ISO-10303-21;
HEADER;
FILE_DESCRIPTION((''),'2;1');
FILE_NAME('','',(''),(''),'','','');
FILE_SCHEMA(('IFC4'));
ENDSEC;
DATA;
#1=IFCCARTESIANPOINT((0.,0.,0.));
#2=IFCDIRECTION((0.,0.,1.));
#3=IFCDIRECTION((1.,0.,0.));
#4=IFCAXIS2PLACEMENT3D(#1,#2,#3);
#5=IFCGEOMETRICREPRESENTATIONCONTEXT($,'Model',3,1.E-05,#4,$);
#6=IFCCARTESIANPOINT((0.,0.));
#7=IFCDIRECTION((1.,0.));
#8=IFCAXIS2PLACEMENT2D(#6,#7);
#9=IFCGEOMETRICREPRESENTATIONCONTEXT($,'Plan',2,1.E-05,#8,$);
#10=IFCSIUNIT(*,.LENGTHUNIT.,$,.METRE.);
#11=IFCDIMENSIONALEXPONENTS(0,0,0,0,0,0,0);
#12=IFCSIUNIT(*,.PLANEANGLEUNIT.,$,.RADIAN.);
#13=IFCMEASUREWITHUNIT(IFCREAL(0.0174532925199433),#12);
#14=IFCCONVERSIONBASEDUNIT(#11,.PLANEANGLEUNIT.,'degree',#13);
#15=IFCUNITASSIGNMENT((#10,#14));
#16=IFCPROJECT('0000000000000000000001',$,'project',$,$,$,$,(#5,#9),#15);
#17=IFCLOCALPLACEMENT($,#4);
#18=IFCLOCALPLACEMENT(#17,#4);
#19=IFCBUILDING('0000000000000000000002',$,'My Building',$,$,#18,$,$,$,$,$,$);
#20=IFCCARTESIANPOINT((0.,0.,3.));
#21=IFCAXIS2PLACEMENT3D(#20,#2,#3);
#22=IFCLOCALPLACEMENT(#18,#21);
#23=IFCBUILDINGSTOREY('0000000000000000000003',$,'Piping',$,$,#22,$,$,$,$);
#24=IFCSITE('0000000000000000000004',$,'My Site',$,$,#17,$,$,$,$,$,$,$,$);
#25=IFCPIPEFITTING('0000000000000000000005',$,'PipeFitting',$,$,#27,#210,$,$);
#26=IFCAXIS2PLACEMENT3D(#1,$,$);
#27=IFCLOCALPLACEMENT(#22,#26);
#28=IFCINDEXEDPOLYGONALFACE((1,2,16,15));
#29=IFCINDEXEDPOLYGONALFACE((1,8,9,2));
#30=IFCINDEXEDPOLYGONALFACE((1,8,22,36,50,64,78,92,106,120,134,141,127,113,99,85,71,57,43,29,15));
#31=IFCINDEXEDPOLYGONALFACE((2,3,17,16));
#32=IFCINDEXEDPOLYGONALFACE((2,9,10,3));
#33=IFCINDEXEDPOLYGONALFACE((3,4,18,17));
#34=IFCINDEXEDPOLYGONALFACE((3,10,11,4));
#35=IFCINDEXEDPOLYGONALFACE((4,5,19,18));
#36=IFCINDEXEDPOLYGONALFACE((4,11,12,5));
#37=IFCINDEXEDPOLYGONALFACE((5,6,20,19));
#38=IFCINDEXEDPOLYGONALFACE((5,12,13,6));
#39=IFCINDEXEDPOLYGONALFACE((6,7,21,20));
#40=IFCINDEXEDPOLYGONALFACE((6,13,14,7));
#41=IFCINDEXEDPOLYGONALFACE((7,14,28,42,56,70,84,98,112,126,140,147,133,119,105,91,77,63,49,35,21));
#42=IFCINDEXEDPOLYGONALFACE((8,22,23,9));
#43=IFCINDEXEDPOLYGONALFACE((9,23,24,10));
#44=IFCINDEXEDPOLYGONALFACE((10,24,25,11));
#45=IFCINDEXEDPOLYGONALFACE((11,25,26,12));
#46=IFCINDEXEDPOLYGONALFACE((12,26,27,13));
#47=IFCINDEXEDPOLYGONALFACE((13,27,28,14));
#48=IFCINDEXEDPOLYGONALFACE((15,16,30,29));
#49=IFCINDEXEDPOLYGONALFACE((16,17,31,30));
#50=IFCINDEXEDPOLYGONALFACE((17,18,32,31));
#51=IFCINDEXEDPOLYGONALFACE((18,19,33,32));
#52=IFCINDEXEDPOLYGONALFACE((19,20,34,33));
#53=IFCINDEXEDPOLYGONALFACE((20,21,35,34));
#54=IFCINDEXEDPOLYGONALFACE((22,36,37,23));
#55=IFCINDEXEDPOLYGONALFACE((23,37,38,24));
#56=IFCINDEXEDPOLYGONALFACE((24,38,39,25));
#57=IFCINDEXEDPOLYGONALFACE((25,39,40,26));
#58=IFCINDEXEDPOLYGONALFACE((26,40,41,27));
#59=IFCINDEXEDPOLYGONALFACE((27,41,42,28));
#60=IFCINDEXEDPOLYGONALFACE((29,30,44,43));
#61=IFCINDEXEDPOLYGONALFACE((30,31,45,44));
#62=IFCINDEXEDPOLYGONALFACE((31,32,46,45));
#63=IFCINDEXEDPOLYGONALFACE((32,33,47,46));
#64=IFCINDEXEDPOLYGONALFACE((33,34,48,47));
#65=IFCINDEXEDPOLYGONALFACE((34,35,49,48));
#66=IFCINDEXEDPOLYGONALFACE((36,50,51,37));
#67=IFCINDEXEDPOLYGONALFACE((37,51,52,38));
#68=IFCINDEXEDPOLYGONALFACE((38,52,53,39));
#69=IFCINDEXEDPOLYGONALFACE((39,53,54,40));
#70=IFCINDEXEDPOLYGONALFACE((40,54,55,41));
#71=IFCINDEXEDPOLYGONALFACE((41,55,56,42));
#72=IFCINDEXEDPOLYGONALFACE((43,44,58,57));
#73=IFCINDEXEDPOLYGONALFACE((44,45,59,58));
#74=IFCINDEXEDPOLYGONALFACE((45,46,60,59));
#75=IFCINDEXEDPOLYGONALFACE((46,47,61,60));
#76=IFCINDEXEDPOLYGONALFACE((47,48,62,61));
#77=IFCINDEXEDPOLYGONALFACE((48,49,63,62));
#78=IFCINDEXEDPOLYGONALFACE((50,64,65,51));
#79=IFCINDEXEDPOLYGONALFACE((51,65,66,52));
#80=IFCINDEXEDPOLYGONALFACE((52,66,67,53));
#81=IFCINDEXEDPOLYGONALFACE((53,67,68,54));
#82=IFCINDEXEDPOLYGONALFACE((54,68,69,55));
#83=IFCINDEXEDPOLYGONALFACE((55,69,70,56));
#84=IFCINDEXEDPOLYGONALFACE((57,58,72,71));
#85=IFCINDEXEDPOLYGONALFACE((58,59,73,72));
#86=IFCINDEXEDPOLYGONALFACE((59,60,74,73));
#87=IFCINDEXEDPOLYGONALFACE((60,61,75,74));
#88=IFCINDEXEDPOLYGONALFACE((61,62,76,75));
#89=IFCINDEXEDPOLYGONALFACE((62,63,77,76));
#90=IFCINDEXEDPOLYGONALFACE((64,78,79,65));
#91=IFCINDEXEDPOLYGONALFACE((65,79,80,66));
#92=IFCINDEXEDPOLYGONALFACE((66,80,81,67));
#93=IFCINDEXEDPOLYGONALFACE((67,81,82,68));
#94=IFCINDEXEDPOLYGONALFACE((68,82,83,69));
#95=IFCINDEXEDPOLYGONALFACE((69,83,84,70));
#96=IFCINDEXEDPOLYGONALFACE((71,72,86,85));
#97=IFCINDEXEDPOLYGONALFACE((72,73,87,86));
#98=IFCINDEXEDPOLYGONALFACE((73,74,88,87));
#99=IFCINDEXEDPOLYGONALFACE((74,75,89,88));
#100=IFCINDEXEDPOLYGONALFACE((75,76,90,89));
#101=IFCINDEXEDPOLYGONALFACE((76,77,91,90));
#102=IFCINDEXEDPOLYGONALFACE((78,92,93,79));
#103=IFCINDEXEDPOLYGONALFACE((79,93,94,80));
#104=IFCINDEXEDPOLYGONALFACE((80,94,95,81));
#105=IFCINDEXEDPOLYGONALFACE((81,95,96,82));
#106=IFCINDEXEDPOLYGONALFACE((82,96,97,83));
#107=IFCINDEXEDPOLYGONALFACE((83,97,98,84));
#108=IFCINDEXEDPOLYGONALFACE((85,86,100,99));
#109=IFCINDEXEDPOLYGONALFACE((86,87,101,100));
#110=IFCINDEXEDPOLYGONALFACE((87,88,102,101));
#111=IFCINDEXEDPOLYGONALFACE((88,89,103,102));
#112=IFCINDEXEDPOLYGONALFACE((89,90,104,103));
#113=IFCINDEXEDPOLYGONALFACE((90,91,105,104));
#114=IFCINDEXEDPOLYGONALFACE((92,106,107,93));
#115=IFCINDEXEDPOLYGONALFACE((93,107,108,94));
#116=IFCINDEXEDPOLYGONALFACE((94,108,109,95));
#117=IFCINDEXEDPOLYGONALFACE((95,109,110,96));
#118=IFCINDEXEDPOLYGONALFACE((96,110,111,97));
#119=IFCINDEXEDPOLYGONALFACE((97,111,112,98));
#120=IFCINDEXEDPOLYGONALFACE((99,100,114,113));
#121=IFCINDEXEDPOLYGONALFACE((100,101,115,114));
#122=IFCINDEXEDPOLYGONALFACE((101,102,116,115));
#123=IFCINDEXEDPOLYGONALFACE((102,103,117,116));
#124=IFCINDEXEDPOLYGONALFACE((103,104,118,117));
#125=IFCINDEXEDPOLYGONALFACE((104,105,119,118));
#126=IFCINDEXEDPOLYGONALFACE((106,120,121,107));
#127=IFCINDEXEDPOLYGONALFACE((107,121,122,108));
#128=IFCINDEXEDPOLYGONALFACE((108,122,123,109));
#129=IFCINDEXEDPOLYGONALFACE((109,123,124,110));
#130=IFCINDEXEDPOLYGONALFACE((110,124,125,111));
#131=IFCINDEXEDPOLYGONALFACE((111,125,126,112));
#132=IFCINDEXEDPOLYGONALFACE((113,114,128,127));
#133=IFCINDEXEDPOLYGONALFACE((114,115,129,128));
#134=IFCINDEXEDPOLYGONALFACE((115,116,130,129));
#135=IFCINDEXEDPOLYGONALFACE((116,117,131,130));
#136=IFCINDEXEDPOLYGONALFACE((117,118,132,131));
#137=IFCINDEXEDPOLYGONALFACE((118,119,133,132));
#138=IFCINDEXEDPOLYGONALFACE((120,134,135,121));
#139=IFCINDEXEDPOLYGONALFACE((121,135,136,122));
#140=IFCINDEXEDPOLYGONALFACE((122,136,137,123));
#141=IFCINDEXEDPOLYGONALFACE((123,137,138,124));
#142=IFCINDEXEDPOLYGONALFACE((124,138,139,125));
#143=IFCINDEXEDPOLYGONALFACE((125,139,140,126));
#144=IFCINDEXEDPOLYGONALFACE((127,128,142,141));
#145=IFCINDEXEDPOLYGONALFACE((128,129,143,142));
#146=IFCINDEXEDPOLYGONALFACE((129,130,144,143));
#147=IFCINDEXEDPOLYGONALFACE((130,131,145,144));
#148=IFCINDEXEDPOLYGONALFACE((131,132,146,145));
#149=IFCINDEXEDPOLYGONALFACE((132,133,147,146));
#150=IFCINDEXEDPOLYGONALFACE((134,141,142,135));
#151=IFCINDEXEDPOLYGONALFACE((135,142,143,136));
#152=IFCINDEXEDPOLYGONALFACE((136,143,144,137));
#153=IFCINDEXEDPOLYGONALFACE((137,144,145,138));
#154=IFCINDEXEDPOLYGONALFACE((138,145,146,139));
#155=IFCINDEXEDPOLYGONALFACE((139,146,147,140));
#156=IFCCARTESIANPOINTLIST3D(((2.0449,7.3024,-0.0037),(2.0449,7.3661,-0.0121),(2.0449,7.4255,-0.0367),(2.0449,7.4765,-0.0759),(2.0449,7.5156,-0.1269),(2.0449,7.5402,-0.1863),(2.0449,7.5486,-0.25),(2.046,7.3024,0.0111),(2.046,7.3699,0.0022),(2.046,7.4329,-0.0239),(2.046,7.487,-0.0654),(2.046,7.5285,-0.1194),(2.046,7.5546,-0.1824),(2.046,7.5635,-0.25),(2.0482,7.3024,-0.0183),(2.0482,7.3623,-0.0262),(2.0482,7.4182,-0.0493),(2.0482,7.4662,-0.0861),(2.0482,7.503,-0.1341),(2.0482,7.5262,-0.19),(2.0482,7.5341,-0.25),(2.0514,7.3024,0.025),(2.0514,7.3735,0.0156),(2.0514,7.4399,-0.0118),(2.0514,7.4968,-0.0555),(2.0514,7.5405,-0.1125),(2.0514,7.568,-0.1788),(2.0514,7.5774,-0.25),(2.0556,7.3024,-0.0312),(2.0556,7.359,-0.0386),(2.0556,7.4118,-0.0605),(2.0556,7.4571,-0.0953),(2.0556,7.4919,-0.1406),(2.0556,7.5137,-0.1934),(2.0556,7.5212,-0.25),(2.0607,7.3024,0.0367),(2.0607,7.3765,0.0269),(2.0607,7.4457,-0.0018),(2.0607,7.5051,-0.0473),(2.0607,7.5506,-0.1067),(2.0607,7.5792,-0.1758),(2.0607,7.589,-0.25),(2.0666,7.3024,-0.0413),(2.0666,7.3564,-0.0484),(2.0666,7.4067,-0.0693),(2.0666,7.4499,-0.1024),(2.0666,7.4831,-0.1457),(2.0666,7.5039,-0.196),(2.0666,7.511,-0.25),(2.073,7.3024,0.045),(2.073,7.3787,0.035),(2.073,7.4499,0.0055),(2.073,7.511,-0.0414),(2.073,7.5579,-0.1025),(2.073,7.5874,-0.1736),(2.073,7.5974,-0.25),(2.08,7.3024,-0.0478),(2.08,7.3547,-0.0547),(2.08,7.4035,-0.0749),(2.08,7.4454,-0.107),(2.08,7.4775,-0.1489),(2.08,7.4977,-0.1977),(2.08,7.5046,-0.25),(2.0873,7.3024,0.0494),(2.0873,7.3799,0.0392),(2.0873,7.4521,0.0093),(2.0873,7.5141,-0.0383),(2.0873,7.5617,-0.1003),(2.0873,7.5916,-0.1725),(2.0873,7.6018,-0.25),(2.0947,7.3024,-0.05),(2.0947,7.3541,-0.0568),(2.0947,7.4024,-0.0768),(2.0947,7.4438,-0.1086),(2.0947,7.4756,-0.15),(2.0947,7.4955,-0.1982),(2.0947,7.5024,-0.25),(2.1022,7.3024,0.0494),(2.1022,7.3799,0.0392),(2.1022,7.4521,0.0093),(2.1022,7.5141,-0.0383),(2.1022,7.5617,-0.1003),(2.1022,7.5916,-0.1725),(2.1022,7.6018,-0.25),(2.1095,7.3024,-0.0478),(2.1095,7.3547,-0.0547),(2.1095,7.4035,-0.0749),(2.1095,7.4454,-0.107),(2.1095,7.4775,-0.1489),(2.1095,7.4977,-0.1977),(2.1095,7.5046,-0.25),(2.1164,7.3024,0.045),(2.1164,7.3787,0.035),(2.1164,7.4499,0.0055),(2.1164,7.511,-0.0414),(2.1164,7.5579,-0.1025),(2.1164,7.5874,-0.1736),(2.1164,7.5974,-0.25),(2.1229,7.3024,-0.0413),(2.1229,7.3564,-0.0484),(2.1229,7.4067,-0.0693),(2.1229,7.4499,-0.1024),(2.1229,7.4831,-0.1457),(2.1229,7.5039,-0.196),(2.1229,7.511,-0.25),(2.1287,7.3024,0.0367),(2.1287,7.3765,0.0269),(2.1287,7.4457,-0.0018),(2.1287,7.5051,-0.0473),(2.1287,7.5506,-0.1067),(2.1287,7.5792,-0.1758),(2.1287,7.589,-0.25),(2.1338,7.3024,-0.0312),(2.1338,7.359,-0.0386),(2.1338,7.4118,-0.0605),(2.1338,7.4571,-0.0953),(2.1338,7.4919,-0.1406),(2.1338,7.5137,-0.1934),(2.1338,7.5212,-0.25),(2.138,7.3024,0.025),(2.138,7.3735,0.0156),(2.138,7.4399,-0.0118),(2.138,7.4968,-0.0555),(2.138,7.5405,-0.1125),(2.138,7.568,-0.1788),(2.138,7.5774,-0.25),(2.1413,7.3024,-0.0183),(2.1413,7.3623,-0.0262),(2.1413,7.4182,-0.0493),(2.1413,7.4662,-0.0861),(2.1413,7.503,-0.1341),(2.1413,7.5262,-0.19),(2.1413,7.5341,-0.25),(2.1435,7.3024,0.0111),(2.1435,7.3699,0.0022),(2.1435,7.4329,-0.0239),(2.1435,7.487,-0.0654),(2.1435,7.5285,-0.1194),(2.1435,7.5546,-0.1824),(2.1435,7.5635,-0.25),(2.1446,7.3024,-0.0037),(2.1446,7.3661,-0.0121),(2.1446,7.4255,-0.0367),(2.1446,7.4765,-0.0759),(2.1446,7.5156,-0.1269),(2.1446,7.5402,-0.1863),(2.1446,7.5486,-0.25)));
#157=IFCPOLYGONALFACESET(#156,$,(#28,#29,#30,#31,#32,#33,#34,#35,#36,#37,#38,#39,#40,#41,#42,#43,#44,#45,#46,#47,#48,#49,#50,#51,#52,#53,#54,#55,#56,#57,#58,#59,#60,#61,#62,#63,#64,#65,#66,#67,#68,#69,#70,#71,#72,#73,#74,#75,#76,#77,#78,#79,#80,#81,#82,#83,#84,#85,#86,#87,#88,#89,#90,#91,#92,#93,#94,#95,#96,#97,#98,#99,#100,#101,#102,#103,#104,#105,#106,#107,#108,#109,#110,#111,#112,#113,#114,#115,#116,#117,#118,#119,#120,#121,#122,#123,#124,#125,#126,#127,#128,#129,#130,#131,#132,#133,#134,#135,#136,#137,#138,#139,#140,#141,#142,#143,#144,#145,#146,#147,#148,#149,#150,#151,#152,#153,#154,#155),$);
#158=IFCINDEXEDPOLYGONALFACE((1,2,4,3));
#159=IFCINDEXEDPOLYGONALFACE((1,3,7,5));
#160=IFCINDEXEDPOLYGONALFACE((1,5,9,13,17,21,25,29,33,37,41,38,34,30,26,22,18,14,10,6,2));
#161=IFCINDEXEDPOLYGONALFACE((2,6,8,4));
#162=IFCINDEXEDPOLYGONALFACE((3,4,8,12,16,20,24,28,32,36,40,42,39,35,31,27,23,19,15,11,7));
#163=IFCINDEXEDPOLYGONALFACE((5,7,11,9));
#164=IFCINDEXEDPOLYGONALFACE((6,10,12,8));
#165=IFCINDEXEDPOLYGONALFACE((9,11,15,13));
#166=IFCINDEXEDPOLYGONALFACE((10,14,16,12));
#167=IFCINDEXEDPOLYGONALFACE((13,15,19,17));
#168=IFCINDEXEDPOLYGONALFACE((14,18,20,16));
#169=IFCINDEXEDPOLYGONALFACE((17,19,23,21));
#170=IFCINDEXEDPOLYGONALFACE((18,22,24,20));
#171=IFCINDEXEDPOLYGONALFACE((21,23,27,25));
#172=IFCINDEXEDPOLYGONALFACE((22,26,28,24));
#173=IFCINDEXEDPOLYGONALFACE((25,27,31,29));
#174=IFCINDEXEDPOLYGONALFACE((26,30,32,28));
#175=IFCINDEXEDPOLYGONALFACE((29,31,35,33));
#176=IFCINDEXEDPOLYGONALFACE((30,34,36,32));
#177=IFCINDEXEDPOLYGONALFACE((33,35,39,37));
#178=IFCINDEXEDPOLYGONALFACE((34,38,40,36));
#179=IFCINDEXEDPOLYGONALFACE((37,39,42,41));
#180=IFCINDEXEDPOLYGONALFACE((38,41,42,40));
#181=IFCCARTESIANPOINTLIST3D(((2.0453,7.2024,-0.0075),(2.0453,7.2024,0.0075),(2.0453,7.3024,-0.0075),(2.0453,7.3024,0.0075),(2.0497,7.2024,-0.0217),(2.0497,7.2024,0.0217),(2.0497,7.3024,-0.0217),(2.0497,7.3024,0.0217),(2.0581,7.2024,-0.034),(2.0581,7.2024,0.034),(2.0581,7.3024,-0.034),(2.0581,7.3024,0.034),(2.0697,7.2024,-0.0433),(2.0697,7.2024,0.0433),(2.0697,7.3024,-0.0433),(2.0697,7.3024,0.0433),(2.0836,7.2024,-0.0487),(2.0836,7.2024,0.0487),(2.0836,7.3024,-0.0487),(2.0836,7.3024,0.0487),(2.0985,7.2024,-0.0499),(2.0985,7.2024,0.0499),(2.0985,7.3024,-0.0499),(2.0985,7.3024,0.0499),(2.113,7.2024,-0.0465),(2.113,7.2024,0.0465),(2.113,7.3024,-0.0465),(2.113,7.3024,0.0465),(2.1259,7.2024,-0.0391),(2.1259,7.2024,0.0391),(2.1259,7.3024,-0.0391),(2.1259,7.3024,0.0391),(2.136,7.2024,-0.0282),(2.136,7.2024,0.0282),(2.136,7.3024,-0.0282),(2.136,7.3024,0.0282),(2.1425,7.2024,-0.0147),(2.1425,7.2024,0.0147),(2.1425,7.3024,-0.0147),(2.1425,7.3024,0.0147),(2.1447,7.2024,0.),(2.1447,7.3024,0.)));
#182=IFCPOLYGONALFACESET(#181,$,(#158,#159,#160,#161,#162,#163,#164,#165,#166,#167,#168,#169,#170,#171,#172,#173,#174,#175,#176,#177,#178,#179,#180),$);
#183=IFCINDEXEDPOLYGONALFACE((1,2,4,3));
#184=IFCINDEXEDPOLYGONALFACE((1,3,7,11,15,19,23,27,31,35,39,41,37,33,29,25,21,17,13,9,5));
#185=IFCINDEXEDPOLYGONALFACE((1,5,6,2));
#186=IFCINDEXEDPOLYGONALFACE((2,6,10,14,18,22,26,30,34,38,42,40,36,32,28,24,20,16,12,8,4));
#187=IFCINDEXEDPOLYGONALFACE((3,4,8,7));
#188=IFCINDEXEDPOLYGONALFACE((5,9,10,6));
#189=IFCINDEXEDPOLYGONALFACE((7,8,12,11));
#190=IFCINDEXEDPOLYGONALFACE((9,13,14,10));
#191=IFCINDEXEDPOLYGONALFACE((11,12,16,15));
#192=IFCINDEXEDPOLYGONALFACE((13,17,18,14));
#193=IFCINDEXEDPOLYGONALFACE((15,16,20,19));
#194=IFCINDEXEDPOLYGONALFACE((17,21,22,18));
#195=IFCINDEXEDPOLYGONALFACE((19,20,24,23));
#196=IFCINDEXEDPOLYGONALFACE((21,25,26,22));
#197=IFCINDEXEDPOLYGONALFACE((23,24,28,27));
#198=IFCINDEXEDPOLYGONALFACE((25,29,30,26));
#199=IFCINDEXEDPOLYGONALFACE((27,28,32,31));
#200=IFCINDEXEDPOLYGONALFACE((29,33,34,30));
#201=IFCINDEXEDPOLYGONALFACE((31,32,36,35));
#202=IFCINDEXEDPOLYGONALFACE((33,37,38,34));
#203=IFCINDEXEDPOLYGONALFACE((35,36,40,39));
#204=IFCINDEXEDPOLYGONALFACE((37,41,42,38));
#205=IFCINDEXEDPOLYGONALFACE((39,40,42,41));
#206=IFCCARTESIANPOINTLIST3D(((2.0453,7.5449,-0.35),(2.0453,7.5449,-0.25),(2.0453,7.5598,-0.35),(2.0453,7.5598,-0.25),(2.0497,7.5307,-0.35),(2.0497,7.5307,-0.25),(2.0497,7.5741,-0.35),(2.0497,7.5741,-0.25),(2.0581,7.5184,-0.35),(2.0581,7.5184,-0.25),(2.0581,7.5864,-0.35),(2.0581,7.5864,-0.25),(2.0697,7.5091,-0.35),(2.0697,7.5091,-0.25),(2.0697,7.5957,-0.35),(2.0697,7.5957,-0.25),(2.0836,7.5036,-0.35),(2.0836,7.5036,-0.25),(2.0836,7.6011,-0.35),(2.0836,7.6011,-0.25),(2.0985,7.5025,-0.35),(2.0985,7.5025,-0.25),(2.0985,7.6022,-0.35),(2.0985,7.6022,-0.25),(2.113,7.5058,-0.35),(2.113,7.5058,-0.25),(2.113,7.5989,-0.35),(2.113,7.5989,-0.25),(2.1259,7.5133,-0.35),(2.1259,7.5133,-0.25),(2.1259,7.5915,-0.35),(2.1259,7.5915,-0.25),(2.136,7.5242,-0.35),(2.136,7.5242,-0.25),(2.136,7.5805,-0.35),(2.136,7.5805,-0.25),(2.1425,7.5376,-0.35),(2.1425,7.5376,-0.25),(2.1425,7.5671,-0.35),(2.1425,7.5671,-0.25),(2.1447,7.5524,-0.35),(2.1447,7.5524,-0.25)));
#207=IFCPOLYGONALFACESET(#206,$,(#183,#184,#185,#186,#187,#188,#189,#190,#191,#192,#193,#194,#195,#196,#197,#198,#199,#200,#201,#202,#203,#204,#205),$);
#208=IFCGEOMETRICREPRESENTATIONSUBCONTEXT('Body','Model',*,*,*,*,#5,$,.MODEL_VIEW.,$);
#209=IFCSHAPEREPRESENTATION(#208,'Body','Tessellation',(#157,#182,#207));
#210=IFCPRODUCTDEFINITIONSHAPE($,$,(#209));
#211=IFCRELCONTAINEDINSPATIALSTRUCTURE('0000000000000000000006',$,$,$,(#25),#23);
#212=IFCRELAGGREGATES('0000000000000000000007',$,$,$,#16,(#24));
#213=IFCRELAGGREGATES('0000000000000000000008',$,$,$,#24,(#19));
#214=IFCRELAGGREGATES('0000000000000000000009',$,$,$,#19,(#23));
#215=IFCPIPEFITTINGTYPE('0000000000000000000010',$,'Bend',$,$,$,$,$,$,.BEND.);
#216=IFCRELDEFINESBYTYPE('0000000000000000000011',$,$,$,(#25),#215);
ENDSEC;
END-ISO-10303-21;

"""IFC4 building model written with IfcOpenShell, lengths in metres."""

from ifc_helpers import new_model, entity, si_unit, converted_unit, frame, origin_with_axes, origin_2d_with_axis, place, context, subcontext, project, spatial, line, indexed_curve, circle, outline, extrude, source, transform, mapped, type_object, type_shapes, element, save


model = new_model("IFC4")

# Units and contexts
model_context = context("Model", 3, precision=1e-05, world=origin_with_axes())
plan_context = context("Plan", 2, precision=1e-05, world=origin_2d_with_axis())
body_context = subcontext(model_context, "Body", "Model", "MODEL_VIEW")
ifc_project = project(units=[si_unit("LENGTHUNIT", "METRE"), converted_unit("PLANEANGLEUNIT", "degree", entity("IfcReal", 0.0174532925199433), si_unit("PLANEANGLEUNIT", "RADIAN"), dimensions=[0, 0, 0, 0, 0, 0, 0])], contexts=[model_context, plan_context])

# Site, building, storey
site_placement = place(None, origin_with_axes())
site = spatial("IfcSite", under=ifc_project, at=site_placement, Name="My Site")
building_placement = place(site_placement, origin_with_axes())
building = spatial("IfcBuilding", under=site, at=building_placement, Name="My Building")
storey_placement = place(building_placement, frame((0.0, 0.0, 3.0), z_axis=(0.0, 0.0, 1.0), x_axis=(1.0, 0.0, 0.0)))
storey = spatial("IfcBuildingStorey", under=building, at=storey_placement, Name="Piping")

# Shared definitions
pipe_fitting_type_1 = type_object("IfcPipeFittingType", Name="Bend", PredefinedType="BEND")
shared_shape = source(origin_with_axes(), body_context, "Body", "SolidModel", [
    entity("IfcSweptDiskSolid", entity("IfcIndexedPolyCurve", entity("IfcCartesianPointList3D", [[0.0, 0.0, -0.1], [0.0, -0.0732, -0.2768], [0.0, -0.25, -0.35]]), [entity("IfcArcIndex", [1, 2, 3])]), 0.05),
    extrude(circle(Radius=0.05), origin_with_axes(), (0.0, 0.0, -1.0), 0.1),
    extrude(circle(Radius=0.05), frame((0.0, -0.25, -0.35), z_axis=(0.0, -1.0, 0.0), x_axis=(1.0, 0.0, 0.0)), (0.0, 0.0, 1.0), 0.1),
])
type_shapes(pipe_fitting_type_1, [shared_shape])

# Pipe fitting, opening
pipe_fitting_1_placement = place(storey_placement, frame((2.0947, 7.2024, 0.0), z_axis=(0.0, -1.0, 0.0), x_axis=(1.0, 0.0, 0.0)))
pipe_fitting_1 = element("IfcPipeFitting", 1, at=pipe_fitting_1_placement, inside=storey, type_object=pipe_fitting_type_1, Name="PipeFitting", context=body_context, shape_type="MappedRepresentation", body=[
    mapped(shared_shape, transform((0.0, 0.0, 0.0), x_axis=(1.0, 0.0, 0.0), y_axis=(0.0, 1.0, 0.0), z_axis=(0.0, 0.0, 1.0), scale=1.0)),
])
opening_placement = place(pipe_fitting_1_placement, frame((-2.0947, -3.0, 7.2024), z_axis=(0.0, 1.0, 0.0), x_axis=(1.0, 0.0, 0.0)))
element("IfcOpeningElement", 2, at=opening_placement, cuts=pipe_fitting_1, PredefinedType="OPENING", context=body_context, shape_type="SweptSolid", body=[
    extrude(outline(indexed_curve([(0.0, 0.0), (0.5, 0.0), (0.5, 0.5), (0.0, 0.5)], segments=[line(1, 2, 3, 4, 1)])), origin_with_axes(), (0.0, 0.0, 1.0), 0.5),
])

save(model, "model.ifc")
